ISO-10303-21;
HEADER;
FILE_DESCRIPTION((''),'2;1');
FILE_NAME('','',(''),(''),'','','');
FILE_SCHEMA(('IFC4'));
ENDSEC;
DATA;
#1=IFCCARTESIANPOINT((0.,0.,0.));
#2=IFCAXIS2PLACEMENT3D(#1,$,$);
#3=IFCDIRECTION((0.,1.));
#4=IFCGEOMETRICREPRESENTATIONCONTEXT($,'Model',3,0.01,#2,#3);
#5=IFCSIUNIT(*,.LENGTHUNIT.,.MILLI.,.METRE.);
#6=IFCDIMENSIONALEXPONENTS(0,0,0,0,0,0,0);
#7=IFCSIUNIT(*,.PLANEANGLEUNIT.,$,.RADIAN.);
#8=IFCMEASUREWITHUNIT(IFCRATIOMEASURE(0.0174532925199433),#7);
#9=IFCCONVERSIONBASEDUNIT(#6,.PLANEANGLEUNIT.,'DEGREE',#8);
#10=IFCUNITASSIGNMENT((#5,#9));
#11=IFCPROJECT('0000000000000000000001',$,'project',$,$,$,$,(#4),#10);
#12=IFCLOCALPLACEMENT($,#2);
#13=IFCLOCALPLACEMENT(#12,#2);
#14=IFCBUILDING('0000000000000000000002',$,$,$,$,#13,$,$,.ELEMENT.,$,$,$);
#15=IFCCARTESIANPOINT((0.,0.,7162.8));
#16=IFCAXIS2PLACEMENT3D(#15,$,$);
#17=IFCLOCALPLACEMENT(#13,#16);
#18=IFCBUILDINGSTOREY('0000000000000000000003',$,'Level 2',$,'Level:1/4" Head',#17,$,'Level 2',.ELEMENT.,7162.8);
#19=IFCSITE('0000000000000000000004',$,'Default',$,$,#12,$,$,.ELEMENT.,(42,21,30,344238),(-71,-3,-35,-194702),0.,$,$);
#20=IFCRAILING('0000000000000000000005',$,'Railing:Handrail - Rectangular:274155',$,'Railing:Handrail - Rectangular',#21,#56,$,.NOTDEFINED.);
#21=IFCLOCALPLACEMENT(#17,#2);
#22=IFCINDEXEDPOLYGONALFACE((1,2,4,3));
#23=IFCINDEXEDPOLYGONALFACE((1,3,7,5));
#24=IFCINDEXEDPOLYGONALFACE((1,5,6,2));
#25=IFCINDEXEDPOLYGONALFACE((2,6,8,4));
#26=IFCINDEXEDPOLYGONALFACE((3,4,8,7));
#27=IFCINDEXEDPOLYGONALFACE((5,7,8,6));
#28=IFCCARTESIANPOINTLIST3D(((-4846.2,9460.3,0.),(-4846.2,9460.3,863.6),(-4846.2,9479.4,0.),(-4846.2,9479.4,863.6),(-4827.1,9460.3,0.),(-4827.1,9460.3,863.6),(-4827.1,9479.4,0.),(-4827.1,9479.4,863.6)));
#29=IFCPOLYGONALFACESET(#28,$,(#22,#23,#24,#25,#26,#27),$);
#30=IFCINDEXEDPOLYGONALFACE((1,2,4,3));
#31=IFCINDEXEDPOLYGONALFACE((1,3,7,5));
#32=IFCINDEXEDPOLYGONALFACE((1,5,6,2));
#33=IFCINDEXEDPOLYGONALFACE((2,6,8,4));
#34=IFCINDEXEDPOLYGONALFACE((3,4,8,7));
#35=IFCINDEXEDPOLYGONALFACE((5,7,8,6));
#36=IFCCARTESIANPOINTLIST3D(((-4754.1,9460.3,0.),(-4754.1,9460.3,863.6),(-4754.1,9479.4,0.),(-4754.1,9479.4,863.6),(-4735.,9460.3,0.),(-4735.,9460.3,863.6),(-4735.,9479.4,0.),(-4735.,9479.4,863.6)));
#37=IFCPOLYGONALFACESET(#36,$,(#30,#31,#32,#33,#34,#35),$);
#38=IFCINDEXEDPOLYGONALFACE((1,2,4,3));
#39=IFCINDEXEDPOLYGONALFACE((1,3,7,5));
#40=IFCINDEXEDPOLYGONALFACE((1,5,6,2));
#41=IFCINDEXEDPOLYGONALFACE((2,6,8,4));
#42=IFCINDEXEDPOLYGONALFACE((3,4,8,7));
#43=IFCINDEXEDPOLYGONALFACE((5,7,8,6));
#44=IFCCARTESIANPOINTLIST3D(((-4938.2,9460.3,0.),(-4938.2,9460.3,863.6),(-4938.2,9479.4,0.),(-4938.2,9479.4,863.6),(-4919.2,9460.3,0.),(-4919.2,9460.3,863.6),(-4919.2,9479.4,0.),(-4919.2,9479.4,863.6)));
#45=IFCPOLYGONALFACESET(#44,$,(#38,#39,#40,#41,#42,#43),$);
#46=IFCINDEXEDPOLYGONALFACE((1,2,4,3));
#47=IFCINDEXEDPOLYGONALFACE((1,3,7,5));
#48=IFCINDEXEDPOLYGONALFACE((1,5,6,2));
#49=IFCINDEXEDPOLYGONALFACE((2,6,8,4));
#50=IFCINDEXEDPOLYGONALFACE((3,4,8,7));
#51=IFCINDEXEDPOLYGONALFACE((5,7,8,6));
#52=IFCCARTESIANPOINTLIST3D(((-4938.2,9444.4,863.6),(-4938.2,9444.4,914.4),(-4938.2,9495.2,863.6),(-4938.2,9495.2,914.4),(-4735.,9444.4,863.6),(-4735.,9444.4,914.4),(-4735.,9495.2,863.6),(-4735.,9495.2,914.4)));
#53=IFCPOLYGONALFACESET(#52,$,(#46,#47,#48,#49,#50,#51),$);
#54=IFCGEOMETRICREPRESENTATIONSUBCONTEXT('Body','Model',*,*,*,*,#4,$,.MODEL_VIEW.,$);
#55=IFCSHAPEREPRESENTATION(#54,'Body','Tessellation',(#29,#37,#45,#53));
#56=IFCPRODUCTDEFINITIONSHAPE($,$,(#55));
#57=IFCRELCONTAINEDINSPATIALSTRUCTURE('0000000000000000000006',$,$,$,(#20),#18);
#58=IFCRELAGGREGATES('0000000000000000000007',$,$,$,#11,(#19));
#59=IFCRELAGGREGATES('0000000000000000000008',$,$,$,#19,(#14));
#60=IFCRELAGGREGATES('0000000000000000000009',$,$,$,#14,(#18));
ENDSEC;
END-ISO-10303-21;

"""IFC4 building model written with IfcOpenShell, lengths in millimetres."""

from ifc_helpers import new_model, entity, si_unit, converted_unit, direction, frame, origin, place, context, subcontext, project, spatial, indexed_curve, outline, extrude, element, save


model = new_model("IFC4")

# Units and contexts
model_context = context("Model", 3, precision=0.01, world=origin(), true_north=direction((0.0, 1.0)))
body_context = subcontext(model_context, "Body", "Model", "MODEL_VIEW")
ifc_project = project(units=[si_unit("LENGTHUNIT", "METRE", prefix="MILLI"), converted_unit("PLANEANGLEUNIT", "DEGREE", entity("IfcRatioMeasure", 0.0174532925199433), si_unit("PLANEANGLEUNIT", "RADIAN"), dimensions=[0, 0, 0, 0, 0, 0, 0])], contexts=[model_context])

# Site, building, storey
site_placement = place(None, origin())
site = spatial("IfcSite", under=ifc_project, at=site_placement, Name="Default", CompositionType="ELEMENT", RefLatitude=(42, 21, 30, 344238), RefLongitude=(-71, -3, -35, -194702), RefElevation=0.0)
building_placement = place(site_placement, origin())
building = spatial("IfcBuilding", under=site, at=building_placement, CompositionType="ELEMENT")
storey_placement = place(building_placement, frame((0.0, 0.0, 7162.8)))
storey = spatial("IfcBuildingStorey", under=building, at=storey_placement, Name="Level 2", ObjectType="Level:1/4\" Head", LongName="Level 2", CompositionType="ELEMENT", Elevation=7162.8)

# Railing
railing_1_placement = place(storey_placement, origin())
element("IfcRailing", 1, at=railing_1_placement, inside=storey, Name="Railing:Handrail - Rectangular:274155", ObjectType="Railing:Handrail - Rectangular", PredefinedType="NOTDEFINED", context=body_context, shape_type="SweptSolid", body=[
    extrude(outline(indexed_curve([(-9.5, -9.5), (9.5, -9.5), (9.5, 9.5), (-9.5, 9.5), (-9.5, -9.5)], self_intersect=False)), frame((-4836.6, 9469.8, 0.0)), (0.0, 0.0, 1.0), 863.6),
    extrude(outline(indexed_curve([(-9.5, -9.5), (9.5, -9.5), (9.5, 9.5), (-9.5, 9.5), (-9.5, -9.5)], self_intersect=False)), frame((-4744.6, 9469.8, 0.0)), (0.0, 0.0, 1.0), 863.6),
    extrude(outline(indexed_curve([(-9.5, -9.5), (9.5, -9.5), (9.5, 9.5), (-9.5, 9.5), (-9.5, -9.5)], self_intersect=False)), frame((-4928.7, 9469.8, 0.0)), (0.0, 0.0, 1.0), 863.6),
    extrude(outline(indexed_curve([(-101.6, -25.4), (101.6, -25.4), (101.6, 25.4), (-101.6, 25.4), (-101.6, -25.4)], self_intersect=False)), frame((-4836.6, 9469.8, 863.6)), (0.0, 0.0, 1.0), 50.8),
])

save(model, "model.ifc")
